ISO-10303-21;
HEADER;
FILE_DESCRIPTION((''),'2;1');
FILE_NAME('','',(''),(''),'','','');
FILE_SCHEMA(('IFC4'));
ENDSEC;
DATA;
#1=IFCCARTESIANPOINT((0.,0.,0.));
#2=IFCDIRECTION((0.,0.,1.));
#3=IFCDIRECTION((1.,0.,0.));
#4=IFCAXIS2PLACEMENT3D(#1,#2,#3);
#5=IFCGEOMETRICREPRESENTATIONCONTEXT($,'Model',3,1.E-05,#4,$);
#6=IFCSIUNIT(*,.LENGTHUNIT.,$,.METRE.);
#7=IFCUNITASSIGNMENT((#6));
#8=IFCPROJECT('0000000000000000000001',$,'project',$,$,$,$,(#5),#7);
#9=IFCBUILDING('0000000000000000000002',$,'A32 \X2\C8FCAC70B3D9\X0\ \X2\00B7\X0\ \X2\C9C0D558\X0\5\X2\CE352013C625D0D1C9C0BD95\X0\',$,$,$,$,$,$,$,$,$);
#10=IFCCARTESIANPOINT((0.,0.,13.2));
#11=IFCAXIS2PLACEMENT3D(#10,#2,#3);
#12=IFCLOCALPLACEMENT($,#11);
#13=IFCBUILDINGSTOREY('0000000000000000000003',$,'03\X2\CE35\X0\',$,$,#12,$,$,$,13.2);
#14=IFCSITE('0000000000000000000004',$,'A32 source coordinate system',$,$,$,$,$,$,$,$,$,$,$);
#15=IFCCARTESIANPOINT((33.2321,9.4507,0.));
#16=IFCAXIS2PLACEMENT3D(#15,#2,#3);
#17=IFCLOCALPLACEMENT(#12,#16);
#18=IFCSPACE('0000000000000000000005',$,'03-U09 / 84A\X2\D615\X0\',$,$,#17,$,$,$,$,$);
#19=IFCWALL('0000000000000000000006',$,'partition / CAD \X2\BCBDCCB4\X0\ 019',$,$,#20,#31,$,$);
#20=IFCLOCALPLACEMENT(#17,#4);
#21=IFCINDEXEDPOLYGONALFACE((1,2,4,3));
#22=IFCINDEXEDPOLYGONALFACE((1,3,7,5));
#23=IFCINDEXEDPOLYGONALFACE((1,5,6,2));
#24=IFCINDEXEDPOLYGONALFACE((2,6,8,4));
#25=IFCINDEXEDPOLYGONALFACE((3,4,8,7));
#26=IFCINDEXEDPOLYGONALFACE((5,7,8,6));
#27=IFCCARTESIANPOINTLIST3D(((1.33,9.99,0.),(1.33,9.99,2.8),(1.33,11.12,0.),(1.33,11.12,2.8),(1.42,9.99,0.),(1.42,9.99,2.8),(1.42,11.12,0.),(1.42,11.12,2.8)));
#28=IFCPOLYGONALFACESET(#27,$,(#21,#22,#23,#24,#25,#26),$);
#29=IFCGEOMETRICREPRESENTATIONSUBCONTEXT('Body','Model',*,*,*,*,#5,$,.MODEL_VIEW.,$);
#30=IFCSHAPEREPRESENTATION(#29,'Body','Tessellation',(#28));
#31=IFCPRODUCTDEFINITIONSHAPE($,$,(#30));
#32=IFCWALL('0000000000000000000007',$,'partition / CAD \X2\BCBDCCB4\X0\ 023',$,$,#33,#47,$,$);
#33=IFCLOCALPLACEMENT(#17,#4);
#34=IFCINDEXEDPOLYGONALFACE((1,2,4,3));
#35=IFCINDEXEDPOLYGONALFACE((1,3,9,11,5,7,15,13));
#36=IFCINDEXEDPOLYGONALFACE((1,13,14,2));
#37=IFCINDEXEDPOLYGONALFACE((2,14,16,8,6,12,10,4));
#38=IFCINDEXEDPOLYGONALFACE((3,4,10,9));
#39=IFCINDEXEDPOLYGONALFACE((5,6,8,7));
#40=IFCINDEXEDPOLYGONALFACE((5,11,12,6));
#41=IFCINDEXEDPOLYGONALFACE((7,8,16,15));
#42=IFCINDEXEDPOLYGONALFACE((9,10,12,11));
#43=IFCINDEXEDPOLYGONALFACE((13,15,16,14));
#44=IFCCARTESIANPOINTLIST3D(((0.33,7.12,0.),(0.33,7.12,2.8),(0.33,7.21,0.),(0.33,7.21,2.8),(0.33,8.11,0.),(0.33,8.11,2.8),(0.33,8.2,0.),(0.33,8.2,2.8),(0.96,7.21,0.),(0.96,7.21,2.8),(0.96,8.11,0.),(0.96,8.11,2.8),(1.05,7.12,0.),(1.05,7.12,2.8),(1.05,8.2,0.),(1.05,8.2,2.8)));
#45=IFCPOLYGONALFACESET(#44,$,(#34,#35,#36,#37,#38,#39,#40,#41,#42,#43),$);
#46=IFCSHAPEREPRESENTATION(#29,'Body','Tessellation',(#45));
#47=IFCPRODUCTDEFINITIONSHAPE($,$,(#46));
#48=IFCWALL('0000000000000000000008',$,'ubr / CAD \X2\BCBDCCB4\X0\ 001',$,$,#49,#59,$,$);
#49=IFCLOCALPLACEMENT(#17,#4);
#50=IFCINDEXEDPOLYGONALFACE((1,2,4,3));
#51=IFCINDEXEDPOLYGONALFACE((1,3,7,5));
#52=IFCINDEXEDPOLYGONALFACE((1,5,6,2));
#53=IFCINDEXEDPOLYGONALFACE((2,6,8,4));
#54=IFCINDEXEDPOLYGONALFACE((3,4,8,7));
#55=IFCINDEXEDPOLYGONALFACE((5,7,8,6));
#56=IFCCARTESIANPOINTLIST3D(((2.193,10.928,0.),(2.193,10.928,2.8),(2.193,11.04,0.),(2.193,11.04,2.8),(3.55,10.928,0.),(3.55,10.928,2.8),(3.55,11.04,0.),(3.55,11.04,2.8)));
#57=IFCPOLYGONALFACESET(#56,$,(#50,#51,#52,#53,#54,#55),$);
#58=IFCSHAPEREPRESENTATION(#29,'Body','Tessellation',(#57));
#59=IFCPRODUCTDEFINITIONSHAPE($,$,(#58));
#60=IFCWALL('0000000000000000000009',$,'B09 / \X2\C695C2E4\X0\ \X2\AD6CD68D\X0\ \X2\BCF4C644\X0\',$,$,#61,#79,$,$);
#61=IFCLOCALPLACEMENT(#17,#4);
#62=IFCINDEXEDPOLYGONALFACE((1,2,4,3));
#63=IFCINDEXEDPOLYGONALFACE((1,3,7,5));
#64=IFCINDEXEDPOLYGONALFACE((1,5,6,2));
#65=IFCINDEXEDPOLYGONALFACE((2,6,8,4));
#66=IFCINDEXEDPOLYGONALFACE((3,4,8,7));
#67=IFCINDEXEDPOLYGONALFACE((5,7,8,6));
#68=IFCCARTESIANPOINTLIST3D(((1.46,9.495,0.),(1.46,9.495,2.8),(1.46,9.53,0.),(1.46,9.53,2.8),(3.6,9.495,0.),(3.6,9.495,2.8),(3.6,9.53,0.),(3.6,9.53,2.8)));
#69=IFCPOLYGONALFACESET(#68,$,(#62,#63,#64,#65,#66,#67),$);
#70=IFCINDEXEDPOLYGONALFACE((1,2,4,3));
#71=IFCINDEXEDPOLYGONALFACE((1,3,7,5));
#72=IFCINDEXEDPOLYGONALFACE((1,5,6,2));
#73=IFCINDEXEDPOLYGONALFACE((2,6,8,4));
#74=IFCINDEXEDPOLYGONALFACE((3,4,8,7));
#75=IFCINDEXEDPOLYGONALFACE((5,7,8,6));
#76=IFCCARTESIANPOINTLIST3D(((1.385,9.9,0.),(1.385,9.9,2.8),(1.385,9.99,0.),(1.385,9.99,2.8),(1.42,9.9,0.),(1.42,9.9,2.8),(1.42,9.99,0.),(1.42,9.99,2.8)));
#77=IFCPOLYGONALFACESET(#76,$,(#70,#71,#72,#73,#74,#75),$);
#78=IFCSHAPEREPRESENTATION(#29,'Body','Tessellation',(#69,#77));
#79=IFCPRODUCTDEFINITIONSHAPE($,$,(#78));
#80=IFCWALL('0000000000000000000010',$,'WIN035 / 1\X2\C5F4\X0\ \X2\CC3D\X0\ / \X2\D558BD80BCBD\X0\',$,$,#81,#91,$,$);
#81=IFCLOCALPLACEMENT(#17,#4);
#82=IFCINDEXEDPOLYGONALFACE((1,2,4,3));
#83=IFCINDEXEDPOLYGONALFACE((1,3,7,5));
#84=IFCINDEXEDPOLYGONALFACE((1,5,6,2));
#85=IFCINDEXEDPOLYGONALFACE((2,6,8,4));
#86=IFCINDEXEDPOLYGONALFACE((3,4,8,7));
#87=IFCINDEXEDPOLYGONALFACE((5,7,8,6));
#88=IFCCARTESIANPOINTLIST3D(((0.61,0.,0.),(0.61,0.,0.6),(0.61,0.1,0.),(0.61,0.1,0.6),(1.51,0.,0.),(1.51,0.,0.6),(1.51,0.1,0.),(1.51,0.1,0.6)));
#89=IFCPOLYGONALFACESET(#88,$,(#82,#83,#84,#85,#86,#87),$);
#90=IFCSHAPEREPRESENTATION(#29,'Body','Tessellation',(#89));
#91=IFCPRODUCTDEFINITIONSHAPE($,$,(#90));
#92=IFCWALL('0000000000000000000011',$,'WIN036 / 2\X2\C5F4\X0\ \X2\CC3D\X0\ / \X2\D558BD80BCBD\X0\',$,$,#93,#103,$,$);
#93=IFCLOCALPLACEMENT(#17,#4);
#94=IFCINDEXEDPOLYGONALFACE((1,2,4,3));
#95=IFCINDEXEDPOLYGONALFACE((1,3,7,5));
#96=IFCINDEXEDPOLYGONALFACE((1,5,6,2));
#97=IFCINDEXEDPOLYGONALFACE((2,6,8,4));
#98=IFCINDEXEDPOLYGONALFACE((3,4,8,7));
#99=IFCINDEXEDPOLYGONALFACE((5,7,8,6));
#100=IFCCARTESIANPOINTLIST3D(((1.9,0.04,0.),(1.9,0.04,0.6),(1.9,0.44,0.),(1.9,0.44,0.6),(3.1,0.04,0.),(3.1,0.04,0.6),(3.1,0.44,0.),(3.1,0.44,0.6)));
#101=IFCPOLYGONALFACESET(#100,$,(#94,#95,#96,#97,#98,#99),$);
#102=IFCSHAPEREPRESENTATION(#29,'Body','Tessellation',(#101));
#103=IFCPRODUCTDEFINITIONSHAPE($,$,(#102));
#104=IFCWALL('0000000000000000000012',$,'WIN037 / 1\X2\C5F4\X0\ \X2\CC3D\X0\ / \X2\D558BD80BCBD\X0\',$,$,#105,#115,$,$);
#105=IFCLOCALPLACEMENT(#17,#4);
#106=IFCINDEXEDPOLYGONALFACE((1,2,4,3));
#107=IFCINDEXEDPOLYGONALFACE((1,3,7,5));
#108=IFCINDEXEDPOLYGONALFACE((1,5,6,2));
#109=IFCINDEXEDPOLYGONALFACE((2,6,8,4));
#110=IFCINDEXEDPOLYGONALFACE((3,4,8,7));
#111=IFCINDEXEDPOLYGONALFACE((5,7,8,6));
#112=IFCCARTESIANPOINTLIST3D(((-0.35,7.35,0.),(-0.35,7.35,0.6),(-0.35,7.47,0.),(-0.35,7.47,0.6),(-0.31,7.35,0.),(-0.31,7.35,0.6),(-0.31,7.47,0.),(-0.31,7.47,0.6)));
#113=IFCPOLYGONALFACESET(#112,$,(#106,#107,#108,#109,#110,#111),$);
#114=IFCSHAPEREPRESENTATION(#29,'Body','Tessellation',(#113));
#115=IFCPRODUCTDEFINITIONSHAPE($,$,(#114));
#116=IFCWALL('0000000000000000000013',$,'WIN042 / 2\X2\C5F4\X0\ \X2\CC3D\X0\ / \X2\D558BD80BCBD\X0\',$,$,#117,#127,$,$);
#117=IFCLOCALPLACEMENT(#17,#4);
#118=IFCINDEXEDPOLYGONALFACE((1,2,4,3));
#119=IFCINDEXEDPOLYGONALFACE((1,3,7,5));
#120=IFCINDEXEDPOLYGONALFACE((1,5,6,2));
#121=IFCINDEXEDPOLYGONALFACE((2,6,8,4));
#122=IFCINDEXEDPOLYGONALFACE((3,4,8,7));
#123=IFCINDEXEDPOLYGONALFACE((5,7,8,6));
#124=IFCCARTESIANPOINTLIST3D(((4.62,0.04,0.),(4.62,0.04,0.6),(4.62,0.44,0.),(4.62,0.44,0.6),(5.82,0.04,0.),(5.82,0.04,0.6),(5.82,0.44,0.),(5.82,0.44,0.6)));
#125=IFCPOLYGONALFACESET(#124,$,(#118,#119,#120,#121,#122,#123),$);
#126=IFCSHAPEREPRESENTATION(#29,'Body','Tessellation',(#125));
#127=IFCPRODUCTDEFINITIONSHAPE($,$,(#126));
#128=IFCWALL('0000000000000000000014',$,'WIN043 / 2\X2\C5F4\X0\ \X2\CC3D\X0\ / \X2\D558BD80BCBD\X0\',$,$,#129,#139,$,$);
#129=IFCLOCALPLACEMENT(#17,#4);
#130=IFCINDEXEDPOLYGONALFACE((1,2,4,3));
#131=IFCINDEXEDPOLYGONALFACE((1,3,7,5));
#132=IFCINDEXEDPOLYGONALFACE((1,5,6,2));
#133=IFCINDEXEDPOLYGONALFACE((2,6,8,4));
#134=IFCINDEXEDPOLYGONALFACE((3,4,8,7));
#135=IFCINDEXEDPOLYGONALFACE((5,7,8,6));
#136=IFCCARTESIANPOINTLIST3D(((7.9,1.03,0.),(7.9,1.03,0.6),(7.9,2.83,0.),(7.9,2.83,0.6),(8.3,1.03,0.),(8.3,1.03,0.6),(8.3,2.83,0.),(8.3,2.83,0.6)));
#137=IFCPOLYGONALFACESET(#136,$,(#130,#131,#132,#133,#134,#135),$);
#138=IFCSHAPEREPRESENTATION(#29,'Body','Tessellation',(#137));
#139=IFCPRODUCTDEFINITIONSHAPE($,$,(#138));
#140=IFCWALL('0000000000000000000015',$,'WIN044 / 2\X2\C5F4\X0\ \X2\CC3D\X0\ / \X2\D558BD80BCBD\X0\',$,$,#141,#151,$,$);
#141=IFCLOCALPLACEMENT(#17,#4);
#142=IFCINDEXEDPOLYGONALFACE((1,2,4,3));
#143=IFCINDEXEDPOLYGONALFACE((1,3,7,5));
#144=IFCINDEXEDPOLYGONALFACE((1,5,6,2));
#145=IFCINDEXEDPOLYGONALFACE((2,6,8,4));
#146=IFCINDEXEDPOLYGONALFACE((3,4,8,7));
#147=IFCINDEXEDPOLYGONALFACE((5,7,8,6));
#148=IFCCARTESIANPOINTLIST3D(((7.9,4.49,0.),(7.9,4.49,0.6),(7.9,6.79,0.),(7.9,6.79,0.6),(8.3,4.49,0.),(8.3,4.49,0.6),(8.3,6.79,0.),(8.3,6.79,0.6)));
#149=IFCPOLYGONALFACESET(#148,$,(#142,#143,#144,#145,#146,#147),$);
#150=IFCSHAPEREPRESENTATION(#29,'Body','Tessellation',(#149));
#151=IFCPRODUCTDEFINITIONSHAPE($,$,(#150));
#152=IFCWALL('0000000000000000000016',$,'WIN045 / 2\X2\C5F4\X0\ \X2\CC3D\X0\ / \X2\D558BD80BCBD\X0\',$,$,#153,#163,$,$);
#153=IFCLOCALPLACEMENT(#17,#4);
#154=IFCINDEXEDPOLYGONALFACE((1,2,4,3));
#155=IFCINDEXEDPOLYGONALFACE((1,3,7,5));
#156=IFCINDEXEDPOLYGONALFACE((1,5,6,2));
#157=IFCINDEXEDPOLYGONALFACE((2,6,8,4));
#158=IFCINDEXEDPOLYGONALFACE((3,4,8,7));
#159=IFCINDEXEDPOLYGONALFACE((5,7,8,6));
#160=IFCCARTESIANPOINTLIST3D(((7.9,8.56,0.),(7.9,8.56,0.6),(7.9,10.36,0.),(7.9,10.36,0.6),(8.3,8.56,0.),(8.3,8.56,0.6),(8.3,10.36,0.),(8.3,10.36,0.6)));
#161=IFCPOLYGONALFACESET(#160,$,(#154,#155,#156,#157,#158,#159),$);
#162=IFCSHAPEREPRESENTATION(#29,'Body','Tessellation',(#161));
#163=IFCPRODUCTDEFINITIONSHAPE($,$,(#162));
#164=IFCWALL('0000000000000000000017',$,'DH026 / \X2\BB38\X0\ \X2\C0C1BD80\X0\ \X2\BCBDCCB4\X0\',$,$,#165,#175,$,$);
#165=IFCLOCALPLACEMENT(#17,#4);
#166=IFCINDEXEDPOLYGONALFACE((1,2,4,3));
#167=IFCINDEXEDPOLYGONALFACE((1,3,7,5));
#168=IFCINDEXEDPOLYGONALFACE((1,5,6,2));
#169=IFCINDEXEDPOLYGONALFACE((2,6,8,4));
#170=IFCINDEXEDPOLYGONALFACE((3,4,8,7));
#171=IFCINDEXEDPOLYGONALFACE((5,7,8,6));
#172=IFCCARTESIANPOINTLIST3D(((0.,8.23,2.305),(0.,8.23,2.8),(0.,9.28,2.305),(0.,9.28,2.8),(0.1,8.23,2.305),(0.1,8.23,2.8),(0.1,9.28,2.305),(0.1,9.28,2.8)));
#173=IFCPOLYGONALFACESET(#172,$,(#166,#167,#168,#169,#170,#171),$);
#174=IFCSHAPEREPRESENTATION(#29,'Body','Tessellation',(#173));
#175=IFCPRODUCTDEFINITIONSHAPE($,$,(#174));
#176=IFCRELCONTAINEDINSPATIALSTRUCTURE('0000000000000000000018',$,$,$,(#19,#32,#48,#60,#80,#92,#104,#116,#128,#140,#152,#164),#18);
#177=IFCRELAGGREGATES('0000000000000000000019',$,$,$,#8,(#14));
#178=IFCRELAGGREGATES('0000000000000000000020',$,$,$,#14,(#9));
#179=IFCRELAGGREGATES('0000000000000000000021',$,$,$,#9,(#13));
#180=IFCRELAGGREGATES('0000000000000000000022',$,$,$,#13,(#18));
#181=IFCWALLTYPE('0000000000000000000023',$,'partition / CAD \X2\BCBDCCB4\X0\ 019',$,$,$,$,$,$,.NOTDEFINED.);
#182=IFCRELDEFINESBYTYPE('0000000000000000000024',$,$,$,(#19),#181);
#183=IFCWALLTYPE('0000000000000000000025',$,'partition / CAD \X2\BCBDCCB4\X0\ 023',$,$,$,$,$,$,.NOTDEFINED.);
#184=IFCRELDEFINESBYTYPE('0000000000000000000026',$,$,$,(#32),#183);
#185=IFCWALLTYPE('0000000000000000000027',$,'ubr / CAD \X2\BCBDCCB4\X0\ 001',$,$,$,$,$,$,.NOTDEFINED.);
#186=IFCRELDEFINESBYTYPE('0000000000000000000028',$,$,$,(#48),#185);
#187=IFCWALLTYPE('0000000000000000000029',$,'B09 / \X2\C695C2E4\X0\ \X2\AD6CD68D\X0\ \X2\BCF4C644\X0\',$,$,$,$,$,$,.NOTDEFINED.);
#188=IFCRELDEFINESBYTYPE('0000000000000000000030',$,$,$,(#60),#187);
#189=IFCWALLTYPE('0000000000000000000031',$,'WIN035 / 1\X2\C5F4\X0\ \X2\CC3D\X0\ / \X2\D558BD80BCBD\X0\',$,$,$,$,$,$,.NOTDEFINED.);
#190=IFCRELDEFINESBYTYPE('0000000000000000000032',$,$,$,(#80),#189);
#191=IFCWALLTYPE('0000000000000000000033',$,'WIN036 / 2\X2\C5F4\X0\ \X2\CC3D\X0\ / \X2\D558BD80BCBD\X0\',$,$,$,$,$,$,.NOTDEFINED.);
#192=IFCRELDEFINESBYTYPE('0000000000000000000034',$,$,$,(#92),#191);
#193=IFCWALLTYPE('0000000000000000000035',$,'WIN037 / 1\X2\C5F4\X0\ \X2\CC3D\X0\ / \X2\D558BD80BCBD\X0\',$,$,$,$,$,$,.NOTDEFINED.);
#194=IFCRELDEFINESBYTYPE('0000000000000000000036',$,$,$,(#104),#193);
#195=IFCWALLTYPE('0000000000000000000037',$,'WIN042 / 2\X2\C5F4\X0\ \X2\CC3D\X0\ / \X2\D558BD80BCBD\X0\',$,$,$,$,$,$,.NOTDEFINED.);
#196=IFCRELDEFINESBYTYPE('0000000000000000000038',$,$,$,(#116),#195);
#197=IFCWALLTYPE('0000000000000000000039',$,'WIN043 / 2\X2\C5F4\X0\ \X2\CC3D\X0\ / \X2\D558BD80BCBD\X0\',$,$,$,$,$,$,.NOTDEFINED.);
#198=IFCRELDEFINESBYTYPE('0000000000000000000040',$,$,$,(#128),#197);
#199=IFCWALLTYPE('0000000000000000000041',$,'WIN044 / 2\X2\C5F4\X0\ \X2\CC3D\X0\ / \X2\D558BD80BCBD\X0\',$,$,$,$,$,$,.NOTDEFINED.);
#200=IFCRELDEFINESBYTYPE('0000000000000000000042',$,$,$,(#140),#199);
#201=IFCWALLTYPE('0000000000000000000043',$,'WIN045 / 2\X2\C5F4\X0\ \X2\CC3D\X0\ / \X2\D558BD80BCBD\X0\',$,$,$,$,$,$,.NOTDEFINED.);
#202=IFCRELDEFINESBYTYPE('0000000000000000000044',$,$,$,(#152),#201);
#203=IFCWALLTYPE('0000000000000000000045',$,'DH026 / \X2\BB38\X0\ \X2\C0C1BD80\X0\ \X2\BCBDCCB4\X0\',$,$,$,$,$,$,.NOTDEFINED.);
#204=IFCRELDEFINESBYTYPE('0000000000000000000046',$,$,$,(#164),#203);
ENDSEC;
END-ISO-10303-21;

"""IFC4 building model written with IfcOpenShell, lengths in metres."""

from ifc_helpers import new_model, si_unit, frame, origin, origin_with_axes, place, context, subcontext, project, spatial, polyline, outline, extrude, source, transform, mapped, type_object, type_shapes, element, save


model = new_model("IFC4")

# Units and contexts
model_context = context("Model", 3, precision=1e-05, world=origin_with_axes())
body_context = subcontext(model_context, "Body", "Model", "MODEL_VIEW")
ifc_project = project(units=[si_unit("LENGTHUNIT", "METRE")], contexts=[model_context])

# Site, building, storey, space
site = spatial("IfcSite", under=ifc_project, Name="A32 source coordinate system")
building = spatial("IfcBuilding", under=site, Name="A32 주거동 · 지하5층–옥탑지붕")
storey_placement = place(None, frame((0.0, 0.0, 13.2), z_axis=(0.0, 0.0, 1.0), x_axis=(1.0, 0.0, 0.0)))
storey = spatial("IfcBuildingStorey", under=building, at=storey_placement, Name="03층", Elevation=13.2)
space_placement = place(storey_placement, frame((33.2321, 9.4507, 0.0), z_axis=(0.0, 0.0, 1.0), x_axis=(1.0, 0.0, 0.0)))
space = spatial("IfcSpace", under=storey, at=space_placement, Name="03-U09 / 84A형")

# Walls
wall_type_1 = type_object("IfcWallType", Name="partition / CAD 벽체 019", PredefinedType="NOTDEFINED")
shared_shape_1 = source(origin(), body_context, "Body", "SweptSolid", [
    extrude(outline(polyline([(1.33, 11.12), (1.42, 11.12), (1.42, 9.99), (1.33, 9.99), (1.33, 11.12)])), origin(), (0.0, 0.0, 1.0), 2.8),
])
type_shapes(wall_type_1, [shared_shape_1])
wall_1_placement = place(space_placement, origin_with_axes())
element("IfcWall", 1, at=wall_1_placement, inside=space, type_object=wall_type_1, Name="partition / CAD 벽체 019", context=body_context, shape_type="MappedRepresentation", body=[
    mapped(shared_shape_1, transform((0.0, 0.0, 0.0), scale=1.0)),
])
wall_type_2 = type_object("IfcWallType", Name="partition / CAD 벽체 023", PredefinedType="NOTDEFINED")
shared_shape_2 = source(origin(), body_context, "Body", "SweptSolid", [
    extrude(outline(polyline([(0.96, 8.11), (0.33, 8.11), (0.33, 8.2), (1.05, 8.2), (1.05, 7.12), (0.33, 7.12), (0.33, 7.21), (0.96, 7.21), (0.96, 8.11)])), origin(), (0.0, 0.0, 1.0), 2.8),
])
type_shapes(wall_type_2, [shared_shape_2])
wall_2_placement = place(space_placement, origin_with_axes())
element("IfcWall", 2, at=wall_2_placement, inside=space, type_object=wall_type_2, Name="partition / CAD 벽체 023", context=body_context, shape_type="MappedRepresentation", body=[
    mapped(shared_shape_2, transform((0.0, 0.0, 0.0), scale=1.0)),
])
wall_type_3 = type_object("IfcWallType", Name="ubr / CAD 벽체 001", PredefinedType="NOTDEFINED")
shared_shape_3 = source(origin(), body_context, "Body", "SweptSolid", [
    extrude(outline(polyline([(3.55, 11.04), (3.55, 10.928), (2.193, 10.928), (2.193, 11.04), (3.55, 11.04)])), origin(), (0.0, 0.0, 1.0), 2.8),
])
type_shapes(wall_type_3, [shared_shape_3])
wall_3_placement = place(space_placement, origin_with_axes())
element("IfcWall", 3, at=wall_3_placement, inside=space, type_object=wall_type_3, Name="ubr / CAD 벽체 001", context=body_context, shape_type="MappedRepresentation", body=[
    mapped(shared_shape_3, transform((0.0, 0.0, 0.0), scale=1.0)),
])
wall_type_4 = type_object("IfcWallType", Name="B09 / 욕실 구획 보완", PredefinedType="NOTDEFINED")
shared_shape_4 = source(origin(), body_context, "Body", "SweptSolid", [
    extrude(outline(polyline([(3.6, 9.53), (3.6, 9.495), (1.46, 9.495), (1.46, 9.53), (3.6, 9.53)])), origin(), (0.0, 0.0, 1.0), 2.8),
    extrude(outline(polyline([(1.42, 9.9), (1.385, 9.9), (1.385, 9.99), (1.42, 9.99), (1.42, 9.9)])), origin(), (0.0, 0.0, 1.0), 2.8),
])
type_shapes(wall_type_4, [shared_shape_4])
wall_4_placement = place(space_placement, origin_with_axes())
element("IfcWall", 4, at=wall_4_placement, inside=space, type_object=wall_type_4, Name="B09 / 욕실 구획 보완", context=body_context, shape_type="MappedRepresentation", body=[
    mapped(shared_shape_4, transform((0.0, 0.0, 0.0), scale=1.0)),
])
wall_type_5 = type_object("IfcWallType", Name="WIN035 / 1열 창 / 하부벽", PredefinedType="NOTDEFINED")
shared_shape_5 = source(origin(), body_context, "Body", "SweptSolid", [
    extrude(outline(polyline([(0.61, 0.1), (1.51, 0.1), (1.51, 0.0), (0.61, 0.0), (0.61, 0.1)])), origin(), (0.0, 0.0, 1.0), 0.6),
])
type_shapes(wall_type_5, [shared_shape_5])
wall_5_placement = place(space_placement, origin_with_axes())
element("IfcWall", 5, at=wall_5_placement, inside=space, type_object=wall_type_5, Name="WIN035 / 1열 창 / 하부벽", context=body_context, shape_type="MappedRepresentation", body=[
    mapped(shared_shape_5, transform((0.0, 0.0, 0.0), scale=1.0)),
])
wall_type_6 = type_object("IfcWallType", Name="WIN036 / 2열 창 / 하부벽", PredefinedType="NOTDEFINED")
shared_shape_6 = source(origin(), body_context, "Body", "SweptSolid", [
    extrude(outline(polyline([(1.9, 0.44), (3.1, 0.44), (3.1, 0.04), (1.9, 0.04), (1.9, 0.44)])), origin(), (0.0, 0.0, 1.0), 0.6),
])
type_shapes(wall_type_6, [shared_shape_6])
wall_6_placement = place(space_placement, origin_with_axes())
element("IfcWall", 6, at=wall_6_placement, inside=space, type_object=wall_type_6, Name="WIN036 / 2열 창 / 하부벽", context=body_context, shape_type="MappedRepresentation", body=[
    mapped(shared_shape_6, transform((0.0, 0.0, 0.0), scale=1.0)),
])
wall_type_7 = type_object("IfcWallType", Name="WIN037 / 1열 창 / 하부벽", PredefinedType="NOTDEFINED")
shared_shape_7 = source(origin(), body_context, "Body", "SweptSolid", [
    extrude(outline(polyline([(-0.31, 7.47), (-0.31, 7.35), (-0.35, 7.35), (-0.35, 7.47), (-0.31, 7.47)])), origin(), (0.0, 0.0, 1.0), 0.6),
])
type_shapes(wall_type_7, [shared_shape_7])
wall_7_placement = place(space_placement, origin_with_axes())
element("IfcWall", 7, at=wall_7_placement, inside=space, type_object=wall_type_7, Name="WIN037 / 1열 창 / 하부벽", context=body_context, shape_type="MappedRepresentation", body=[
    mapped(shared_shape_7, transform((0.0, 0.0, 0.0), scale=1.0)),
])
wall_type_8 = type_object("IfcWallType", Name="WIN042 / 2열 창 / 하부벽", PredefinedType="NOTDEFINED")
shared_shape_8 = source(origin(), body_context, "Body", "SweptSolid", [
    extrude(outline(polyline([(4.62, 0.44), (5.82, 0.44), (5.82, 0.04), (4.62, 0.04), (4.62, 0.44)])), origin(), (0.0, 0.0, 1.0), 0.6),
])
type_shapes(wall_type_8, [shared_shape_8])
wall_8_placement = place(space_placement, origin_with_axes())
element("IfcWall", 8, at=wall_8_placement, inside=space, type_object=wall_type_8, Name="WIN042 / 2열 창 / 하부벽", context=body_context, shape_type="MappedRepresentation", body=[
    mapped(shared_shape_8, transform((0.0, 0.0, 0.0), scale=1.0)),
])
wall_type_9 = type_object("IfcWallType", Name="WIN043 / 2열 창 / 하부벽", PredefinedType="NOTDEFINED")
shared_shape_9 = source(origin(), body_context, "Body", "SweptSolid", [
    extrude(outline(polyline([(7.9, 2.83), (8.3, 2.83), (8.3, 1.03), (7.9, 1.03), (7.9, 2.83)])), origin(), (0.0, 0.0, 1.0), 0.6),
])
type_shapes(wall_type_9, [shared_shape_9])
wall_9_placement = place(space_placement, origin_with_axes())
element("IfcWall", 9, at=wall_9_placement, inside=space, type_object=wall_type_9, Name="WIN043 / 2열 창 / 하부벽", context=body_context, shape_type="MappedRepresentation", body=[
    mapped(shared_shape_9, transform((0.0, 0.0, 0.0), scale=1.0)),
])
wall_type_10 = type_object("IfcWallType", Name="WIN044 / 2열 창 / 하부벽", PredefinedType="NOTDEFINED")
shared_shape_10 = source(origin(), body_context, "Body", "SweptSolid", [
    extrude(outline(polyline([(7.9, 6.79), (8.3, 6.79), (8.3, 4.49), (7.9, 4.49), (7.9, 6.79)])), origin(), (0.0, 0.0, 1.0), 0.6),
])
type_shapes(wall_type_10, [shared_shape_10])
wall_10_placement = place(space_placement, origin_with_axes())
element("IfcWall", 10, at=wall_10_placement, inside=space, type_object=wall_type_10, Name="WIN044 / 2열 창 / 하부벽", context=body_context, shape_type="MappedRepresentation", body=[
    mapped(shared_shape_10, transform((0.0, 0.0, 0.0), scale=1.0)),
])
wall_type_11 = type_object("IfcWallType", Name="WIN045 / 2열 창 / 하부벽", PredefinedType="NOTDEFINED")
shared_shape_11 = source(origin(), body_context, "Body", "SweptSolid", [
    extrude(outline(polyline([(7.9, 10.36), (8.3, 10.36), (8.3, 8.56), (7.9, 8.56), (7.9, 10.36)])), origin(), (0.0, 0.0, 1.0), 0.6),
])
type_shapes(wall_type_11, [shared_shape_11])
wall_11_placement = place(space_placement, origin_with_axes())
element("IfcWall", 11, at=wall_11_placement, inside=space, type_object=wall_type_11, Name="WIN045 / 2열 창 / 하부벽", context=body_context, shape_type="MappedRepresentation", body=[
    mapped(shared_shape_11, transform((0.0, 0.0, 0.0), scale=1.0)),
])
wall_type_12 = type_object("IfcWallType", Name="DH026 / 문 상부 벽체", PredefinedType="NOTDEFINED")
shared_shape_12 = source(origin(), body_context, "Body", "SweptSolid", [
    extrude(outline(polyline([(0.1, 9.28), (0.1, 8.23), (0.0, 8.23), (0.0, 9.28), (0.1, 9.28)])), frame((0.0, 0.0, 2.305)), (0.0, 0.0, 1.0), 0.495),
])
type_shapes(wall_type_12, [shared_shape_12])
wall_12_placement = place(space_placement, origin_with_axes())
element("IfcWall", 12, at=wall_12_placement, inside=space, type_object=wall_type_12, Name="DH026 / 문 상부 벽체", context=body_context, shape_type="MappedRepresentation", body=[
    mapped(shared_shape_12, transform((0.0, 0.0, 0.0), scale=1.0)),
])

save(model, "model.ifc")
